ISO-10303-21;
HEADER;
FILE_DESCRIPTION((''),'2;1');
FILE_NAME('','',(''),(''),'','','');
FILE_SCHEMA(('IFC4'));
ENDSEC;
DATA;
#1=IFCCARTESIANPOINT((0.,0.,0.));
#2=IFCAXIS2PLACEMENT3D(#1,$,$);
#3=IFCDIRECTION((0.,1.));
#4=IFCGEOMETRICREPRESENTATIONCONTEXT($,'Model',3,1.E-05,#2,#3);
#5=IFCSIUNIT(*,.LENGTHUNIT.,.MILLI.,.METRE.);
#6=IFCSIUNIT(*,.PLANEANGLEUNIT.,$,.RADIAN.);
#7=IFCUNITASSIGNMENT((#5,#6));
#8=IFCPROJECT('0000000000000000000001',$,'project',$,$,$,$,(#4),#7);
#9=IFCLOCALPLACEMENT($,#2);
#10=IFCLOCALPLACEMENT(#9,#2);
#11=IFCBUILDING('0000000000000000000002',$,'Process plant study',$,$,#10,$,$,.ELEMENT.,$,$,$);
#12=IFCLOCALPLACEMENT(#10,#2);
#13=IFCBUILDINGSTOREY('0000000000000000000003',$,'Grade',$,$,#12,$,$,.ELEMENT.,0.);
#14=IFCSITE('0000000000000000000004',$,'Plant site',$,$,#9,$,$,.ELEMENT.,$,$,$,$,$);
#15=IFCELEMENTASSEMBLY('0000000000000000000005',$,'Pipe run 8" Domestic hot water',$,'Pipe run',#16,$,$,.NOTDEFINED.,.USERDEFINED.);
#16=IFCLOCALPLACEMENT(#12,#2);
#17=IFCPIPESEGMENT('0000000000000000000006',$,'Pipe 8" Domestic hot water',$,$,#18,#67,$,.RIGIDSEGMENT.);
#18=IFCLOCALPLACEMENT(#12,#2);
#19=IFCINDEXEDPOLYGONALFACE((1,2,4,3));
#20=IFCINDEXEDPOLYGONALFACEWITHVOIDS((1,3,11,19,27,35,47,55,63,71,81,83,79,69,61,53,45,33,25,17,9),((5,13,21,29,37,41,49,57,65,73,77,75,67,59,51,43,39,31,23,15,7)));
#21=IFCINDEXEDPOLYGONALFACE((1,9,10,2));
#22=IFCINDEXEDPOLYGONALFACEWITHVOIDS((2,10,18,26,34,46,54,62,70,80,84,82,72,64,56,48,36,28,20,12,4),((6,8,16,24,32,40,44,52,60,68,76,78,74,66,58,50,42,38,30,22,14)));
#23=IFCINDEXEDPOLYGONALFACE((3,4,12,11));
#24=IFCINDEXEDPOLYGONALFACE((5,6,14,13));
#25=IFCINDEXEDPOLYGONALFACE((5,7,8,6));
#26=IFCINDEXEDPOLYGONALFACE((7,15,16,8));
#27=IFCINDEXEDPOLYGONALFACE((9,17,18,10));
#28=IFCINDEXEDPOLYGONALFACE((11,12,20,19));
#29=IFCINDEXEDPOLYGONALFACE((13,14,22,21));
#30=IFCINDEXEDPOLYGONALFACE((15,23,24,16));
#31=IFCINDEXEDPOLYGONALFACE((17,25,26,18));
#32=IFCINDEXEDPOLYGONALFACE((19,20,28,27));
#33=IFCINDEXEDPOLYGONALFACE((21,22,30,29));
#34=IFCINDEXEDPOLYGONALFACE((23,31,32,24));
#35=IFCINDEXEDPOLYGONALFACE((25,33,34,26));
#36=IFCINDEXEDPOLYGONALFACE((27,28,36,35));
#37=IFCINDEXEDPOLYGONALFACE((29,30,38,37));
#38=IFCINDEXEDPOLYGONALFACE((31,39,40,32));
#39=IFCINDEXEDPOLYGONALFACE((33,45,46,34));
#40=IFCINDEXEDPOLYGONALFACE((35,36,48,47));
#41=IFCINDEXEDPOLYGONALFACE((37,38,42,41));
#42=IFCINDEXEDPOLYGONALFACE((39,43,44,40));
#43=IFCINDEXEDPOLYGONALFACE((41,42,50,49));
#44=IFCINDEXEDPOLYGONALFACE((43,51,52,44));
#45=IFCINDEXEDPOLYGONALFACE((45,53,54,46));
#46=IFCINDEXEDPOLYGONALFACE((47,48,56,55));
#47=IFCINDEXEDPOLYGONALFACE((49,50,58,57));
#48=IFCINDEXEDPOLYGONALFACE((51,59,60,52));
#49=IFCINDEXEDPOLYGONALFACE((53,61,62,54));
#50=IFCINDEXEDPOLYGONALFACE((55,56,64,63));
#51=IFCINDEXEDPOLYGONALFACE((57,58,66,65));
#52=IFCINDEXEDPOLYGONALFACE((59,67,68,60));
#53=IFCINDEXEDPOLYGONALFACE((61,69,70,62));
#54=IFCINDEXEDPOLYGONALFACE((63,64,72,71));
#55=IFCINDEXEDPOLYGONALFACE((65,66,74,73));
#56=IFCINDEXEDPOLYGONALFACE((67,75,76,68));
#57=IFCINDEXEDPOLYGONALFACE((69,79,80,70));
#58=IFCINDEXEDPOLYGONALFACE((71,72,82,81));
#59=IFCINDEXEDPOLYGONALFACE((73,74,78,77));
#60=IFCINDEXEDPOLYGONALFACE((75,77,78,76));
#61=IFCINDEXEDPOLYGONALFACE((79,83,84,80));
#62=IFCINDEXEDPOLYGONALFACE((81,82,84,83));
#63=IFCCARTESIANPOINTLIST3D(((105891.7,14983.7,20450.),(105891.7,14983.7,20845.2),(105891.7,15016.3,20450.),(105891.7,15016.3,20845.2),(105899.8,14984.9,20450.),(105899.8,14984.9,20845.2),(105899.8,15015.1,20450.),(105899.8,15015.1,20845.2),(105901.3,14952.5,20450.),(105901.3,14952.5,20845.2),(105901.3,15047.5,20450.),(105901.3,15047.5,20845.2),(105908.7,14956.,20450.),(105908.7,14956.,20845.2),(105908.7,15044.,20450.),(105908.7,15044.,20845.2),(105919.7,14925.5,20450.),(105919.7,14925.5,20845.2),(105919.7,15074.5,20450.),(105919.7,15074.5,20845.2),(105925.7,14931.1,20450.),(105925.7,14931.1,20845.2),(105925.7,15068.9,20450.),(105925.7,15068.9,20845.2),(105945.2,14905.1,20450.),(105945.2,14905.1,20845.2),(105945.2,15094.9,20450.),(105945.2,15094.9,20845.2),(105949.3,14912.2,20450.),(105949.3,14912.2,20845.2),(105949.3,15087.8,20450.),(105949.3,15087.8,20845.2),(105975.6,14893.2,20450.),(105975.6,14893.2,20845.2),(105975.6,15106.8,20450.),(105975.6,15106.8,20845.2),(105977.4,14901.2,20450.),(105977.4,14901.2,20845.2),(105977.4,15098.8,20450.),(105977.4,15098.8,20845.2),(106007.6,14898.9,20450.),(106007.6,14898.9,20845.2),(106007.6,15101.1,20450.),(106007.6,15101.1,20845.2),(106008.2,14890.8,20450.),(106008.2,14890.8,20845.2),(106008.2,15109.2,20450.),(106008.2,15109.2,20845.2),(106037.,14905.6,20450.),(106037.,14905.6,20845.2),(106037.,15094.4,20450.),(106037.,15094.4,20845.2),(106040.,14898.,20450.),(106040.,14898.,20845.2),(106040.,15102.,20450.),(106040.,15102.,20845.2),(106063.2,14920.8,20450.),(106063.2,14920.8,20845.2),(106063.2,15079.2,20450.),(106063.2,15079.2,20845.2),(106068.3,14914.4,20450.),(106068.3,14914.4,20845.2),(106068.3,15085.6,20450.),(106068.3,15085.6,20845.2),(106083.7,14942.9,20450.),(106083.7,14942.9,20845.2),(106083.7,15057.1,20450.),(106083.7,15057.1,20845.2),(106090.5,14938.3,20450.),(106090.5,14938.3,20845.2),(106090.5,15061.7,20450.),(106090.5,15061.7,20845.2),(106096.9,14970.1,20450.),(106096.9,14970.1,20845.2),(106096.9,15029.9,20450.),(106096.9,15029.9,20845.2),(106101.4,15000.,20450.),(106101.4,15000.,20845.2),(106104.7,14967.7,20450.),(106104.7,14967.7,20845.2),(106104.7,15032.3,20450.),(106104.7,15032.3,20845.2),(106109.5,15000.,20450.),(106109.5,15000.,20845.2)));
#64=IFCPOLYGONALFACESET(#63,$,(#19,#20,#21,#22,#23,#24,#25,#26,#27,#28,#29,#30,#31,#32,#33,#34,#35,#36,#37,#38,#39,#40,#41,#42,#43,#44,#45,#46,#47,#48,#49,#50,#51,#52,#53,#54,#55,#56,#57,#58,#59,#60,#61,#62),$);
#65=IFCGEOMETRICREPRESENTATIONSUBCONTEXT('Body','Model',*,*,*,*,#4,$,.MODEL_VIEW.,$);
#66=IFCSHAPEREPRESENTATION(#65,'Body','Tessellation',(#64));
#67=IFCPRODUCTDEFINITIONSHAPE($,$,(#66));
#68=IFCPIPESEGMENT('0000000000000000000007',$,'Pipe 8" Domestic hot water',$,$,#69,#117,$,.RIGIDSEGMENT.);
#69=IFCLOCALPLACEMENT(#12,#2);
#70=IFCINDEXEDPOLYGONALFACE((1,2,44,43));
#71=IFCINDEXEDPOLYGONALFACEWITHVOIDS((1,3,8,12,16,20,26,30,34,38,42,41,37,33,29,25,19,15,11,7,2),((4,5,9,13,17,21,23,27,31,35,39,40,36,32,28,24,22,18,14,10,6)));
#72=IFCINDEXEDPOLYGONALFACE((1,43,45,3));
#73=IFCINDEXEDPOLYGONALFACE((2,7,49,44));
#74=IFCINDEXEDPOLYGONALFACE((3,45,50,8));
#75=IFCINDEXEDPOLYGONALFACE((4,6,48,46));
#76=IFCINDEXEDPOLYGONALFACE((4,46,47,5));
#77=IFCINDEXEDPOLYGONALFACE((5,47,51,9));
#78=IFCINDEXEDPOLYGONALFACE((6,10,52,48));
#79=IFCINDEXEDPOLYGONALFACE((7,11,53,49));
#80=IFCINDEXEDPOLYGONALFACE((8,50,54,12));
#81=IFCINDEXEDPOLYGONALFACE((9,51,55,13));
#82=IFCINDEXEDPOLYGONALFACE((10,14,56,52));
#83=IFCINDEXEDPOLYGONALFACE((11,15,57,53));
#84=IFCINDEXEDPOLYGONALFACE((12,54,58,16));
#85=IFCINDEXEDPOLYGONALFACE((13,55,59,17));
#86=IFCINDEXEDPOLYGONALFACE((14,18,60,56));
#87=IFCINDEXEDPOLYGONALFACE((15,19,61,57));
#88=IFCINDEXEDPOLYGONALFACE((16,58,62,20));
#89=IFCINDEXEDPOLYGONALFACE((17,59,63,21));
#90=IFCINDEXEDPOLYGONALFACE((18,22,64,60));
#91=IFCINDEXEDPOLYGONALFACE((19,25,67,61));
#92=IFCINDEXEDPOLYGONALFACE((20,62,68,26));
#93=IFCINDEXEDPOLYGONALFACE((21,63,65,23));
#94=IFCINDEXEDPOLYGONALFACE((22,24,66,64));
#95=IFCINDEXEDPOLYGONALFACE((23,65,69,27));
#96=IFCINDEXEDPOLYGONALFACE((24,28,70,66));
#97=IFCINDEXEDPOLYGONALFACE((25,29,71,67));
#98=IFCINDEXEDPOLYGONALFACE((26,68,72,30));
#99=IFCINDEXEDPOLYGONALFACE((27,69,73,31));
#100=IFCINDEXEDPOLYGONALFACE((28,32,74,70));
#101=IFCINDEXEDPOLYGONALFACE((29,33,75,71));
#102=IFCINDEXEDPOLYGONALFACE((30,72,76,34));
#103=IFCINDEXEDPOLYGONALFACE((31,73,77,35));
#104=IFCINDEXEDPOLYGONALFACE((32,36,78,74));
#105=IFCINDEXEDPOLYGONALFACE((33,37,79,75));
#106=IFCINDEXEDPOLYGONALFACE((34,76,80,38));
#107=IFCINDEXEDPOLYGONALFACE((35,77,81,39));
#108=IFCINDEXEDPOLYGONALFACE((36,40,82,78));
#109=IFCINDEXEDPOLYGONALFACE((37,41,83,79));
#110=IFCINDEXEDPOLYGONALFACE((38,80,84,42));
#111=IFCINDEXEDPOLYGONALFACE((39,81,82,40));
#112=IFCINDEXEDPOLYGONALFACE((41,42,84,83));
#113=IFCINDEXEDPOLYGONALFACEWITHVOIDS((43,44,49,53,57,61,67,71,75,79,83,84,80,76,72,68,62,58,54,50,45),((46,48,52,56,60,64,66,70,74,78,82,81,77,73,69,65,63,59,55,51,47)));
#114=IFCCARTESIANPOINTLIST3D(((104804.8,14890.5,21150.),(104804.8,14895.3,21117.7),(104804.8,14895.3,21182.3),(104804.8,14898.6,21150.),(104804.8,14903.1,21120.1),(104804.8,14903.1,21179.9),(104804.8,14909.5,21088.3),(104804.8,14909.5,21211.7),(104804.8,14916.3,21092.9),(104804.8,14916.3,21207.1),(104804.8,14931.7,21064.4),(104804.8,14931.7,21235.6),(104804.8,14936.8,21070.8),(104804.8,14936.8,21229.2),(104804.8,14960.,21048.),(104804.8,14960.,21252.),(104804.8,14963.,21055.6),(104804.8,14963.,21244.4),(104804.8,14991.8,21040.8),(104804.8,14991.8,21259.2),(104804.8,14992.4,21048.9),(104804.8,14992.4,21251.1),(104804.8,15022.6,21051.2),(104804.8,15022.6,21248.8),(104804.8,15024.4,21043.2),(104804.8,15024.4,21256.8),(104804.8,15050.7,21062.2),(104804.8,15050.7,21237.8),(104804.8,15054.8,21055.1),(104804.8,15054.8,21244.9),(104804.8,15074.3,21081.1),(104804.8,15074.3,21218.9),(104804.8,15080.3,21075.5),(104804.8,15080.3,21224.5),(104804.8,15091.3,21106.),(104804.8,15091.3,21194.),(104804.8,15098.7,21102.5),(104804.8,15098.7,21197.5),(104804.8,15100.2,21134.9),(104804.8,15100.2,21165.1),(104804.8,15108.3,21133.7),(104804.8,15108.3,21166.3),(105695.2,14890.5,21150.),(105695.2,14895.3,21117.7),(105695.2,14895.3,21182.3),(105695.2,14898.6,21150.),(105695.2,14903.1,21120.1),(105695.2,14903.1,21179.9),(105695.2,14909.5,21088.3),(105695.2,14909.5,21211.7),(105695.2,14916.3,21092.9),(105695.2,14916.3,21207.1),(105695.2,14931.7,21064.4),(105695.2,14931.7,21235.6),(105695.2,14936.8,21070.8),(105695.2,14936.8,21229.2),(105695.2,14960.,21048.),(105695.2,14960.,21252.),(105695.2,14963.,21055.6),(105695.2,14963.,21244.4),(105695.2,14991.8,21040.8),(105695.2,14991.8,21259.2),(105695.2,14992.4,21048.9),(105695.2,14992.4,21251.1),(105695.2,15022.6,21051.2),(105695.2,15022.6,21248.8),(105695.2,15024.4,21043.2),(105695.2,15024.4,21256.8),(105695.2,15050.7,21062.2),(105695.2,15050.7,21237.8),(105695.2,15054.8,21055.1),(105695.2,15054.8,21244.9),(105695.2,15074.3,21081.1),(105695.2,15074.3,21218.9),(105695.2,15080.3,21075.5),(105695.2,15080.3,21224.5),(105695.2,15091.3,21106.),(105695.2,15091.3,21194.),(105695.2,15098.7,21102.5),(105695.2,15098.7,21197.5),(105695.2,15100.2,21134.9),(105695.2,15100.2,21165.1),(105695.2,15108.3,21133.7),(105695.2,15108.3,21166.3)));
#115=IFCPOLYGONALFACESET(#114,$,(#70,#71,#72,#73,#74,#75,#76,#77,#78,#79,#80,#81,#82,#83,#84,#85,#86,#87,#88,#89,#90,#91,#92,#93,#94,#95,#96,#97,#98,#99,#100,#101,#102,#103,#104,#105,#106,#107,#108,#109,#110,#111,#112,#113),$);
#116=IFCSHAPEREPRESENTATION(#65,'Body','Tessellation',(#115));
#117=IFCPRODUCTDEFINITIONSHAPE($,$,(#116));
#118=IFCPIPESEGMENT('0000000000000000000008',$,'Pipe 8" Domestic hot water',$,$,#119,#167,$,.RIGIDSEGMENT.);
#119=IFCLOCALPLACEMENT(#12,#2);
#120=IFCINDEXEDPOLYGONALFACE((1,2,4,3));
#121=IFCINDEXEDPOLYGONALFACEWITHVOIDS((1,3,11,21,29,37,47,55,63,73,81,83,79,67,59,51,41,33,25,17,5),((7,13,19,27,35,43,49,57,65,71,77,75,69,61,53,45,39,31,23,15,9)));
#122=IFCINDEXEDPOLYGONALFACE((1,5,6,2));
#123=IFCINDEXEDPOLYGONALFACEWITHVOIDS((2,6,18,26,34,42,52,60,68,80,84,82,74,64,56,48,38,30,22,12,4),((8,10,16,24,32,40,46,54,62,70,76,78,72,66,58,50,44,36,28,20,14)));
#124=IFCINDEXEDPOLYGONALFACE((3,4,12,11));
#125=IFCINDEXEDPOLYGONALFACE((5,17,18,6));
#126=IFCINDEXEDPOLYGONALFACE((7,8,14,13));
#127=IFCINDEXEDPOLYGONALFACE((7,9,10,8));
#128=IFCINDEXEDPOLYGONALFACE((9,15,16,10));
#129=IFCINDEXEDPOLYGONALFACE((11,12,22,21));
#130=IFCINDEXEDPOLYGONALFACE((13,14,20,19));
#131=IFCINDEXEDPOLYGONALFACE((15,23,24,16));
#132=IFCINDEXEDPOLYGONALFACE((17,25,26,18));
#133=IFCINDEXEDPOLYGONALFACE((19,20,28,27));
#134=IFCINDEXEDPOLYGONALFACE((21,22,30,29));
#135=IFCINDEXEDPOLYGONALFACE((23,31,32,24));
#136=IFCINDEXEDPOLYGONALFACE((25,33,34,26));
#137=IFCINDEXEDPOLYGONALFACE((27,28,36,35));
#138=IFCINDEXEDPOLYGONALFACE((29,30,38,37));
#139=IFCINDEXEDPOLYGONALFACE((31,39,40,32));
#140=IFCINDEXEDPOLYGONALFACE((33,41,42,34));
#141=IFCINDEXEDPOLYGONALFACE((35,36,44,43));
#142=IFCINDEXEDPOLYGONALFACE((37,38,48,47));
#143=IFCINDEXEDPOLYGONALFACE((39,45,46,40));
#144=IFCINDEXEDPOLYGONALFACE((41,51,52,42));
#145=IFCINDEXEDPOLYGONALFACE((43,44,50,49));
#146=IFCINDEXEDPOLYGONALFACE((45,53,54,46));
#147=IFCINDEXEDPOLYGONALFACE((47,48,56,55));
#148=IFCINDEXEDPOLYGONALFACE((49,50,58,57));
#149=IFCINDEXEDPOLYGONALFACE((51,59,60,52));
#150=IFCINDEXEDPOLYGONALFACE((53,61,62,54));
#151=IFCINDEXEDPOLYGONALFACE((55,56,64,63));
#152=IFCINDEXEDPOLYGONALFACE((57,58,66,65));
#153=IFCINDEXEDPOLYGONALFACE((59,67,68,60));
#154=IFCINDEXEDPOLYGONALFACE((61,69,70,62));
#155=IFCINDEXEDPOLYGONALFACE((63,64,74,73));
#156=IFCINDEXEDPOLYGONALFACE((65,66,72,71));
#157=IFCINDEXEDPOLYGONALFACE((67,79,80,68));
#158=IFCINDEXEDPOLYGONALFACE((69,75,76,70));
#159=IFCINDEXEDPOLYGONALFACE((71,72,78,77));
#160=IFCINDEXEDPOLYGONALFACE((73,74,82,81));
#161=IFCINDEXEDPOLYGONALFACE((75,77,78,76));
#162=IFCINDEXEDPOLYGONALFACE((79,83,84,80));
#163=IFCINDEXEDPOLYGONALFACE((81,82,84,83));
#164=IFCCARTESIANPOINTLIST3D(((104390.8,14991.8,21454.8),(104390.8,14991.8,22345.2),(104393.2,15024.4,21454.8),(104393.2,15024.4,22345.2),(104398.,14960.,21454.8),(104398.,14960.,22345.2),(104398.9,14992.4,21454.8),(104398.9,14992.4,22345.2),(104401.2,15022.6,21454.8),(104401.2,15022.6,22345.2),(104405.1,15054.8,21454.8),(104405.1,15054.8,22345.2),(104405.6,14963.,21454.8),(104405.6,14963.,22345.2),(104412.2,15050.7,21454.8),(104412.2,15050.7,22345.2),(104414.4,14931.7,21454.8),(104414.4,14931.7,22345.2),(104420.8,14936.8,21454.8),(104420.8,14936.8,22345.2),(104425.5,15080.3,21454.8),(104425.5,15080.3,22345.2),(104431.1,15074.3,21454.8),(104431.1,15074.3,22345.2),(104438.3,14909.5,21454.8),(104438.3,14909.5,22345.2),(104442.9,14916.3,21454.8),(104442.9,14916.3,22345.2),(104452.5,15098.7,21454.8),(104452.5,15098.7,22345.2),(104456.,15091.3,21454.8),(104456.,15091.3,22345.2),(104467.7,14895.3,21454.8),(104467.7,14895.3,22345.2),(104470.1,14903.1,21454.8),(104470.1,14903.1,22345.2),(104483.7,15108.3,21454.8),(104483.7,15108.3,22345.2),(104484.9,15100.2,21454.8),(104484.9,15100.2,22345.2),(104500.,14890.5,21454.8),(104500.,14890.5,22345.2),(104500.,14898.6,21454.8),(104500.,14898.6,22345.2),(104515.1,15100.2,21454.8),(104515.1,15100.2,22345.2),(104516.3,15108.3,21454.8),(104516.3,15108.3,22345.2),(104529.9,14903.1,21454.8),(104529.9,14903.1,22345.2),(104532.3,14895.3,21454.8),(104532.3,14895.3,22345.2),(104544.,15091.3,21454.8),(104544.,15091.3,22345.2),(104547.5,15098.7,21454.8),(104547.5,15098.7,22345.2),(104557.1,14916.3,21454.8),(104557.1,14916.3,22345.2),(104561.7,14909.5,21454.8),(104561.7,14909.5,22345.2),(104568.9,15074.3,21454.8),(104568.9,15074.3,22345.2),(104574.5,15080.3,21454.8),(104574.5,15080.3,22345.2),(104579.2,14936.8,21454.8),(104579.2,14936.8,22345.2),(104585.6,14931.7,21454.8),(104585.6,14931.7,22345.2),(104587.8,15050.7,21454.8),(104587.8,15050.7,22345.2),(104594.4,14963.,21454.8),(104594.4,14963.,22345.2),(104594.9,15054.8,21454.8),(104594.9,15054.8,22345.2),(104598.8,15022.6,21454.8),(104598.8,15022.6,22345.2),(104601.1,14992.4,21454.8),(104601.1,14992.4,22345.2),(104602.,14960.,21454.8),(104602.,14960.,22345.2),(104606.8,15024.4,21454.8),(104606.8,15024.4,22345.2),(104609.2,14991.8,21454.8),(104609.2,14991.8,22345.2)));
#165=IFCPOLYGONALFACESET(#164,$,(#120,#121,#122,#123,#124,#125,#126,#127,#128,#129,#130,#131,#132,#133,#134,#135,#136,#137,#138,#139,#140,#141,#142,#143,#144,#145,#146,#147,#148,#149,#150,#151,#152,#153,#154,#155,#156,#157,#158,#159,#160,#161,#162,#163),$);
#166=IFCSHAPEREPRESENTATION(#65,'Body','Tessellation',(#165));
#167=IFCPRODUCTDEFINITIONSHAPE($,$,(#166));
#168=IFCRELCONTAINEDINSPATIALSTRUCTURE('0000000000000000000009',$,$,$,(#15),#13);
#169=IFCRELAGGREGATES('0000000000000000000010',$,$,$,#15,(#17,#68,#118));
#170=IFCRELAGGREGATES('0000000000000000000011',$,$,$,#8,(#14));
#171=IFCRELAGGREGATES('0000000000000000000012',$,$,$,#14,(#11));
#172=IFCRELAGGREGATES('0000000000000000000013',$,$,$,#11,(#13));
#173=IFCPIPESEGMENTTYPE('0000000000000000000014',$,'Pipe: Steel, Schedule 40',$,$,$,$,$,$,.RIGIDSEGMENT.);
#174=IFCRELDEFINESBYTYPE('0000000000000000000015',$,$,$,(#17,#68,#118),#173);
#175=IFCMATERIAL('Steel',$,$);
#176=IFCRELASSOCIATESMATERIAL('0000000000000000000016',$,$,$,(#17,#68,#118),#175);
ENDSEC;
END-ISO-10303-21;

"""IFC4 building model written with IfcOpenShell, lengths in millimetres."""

from ifc_helpers import new_model, si_unit, direction, frame, origin, origin_with_axes, origin_2d, place, context, subcontext, project, spatial, hollow_circle, extrude, material, type_object, element, aggregate, save


model = new_model("IFC4")

# Units and contexts
model_context = context("Model", 3, precision=1e-05, world=origin(), true_north=direction((0.0, 1.0)))
body_context = subcontext(model_context, "Body", "Model", "MODEL_VIEW")
ifc_project = project(units=[si_unit("LENGTHUNIT", "METRE", prefix="MILLI"), si_unit("PLANEANGLEUNIT", "RADIAN")], contexts=[model_context])

# Site, building, storey
site_placement = place(None, origin())
site = spatial("IfcSite", under=ifc_project, at=site_placement, Name="Plant site", CompositionType="ELEMENT")
building_placement = place(site_placement, origin())
building = spatial("IfcBuilding", under=site, at=building_placement, Name="Process plant study", CompositionType="ELEMENT")
storey_placement = place(building_placement, origin())
storey = spatial("IfcBuildingStorey", under=building, at=storey_placement, Name="Grade", CompositionType="ELEMENT", Elevation=0.0)

# Element assembly, pipe segments
ifc_material = material(Name="Steel")
pipe_segment_type = type_object("IfcPipeSegmentType", Name="Pipe: Steel, Schedule 40", PredefinedType="RIGIDSEGMENT")
assembly_1_placement = place(storey_placement, origin_with_axes())
assembly_1 = element("IfcElementAssembly", 1, at=assembly_1_placement, inside=storey, Name="Pipe run 8\" Domestic hot water", ObjectType="Pipe run", AssemblyPlace="NOTDEFINED", PredefinedType="USERDEFINED")
pipe_segment_1_placement = place(storey_placement, origin_with_axes())
pipe_segment_1 = element("IfcPipeSegment", 2, at=pipe_segment_1_placement, type_object=pipe_segment_type, material=ifc_material, Name="Pipe 8\" Domestic hot water", PredefinedType="RIGIDSEGMENT", context=body_context, shape_type="SweptSolid", body=[
    extrude(hollow_circle(Radius=109.5, WallThickness=8.2, at=origin_2d()), frame((106000.0, 15000.0, 20450.0), z_axis=(0.0, 0.0, 1.0), x_axis=(1.0, 0.0, 0.0)), (0.0, 0.0, 1.0), 395.2),
])
pipe_segment_2_placement = place(storey_placement, origin_with_axes())
pipe_segment_2 = element("IfcPipeSegment", 3, at=pipe_segment_2_placement, type_object=pipe_segment_type, material=ifc_material, Name="Pipe 8\" Domestic hot water", PredefinedType="RIGIDSEGMENT", context=body_context, shape_type="SweptSolid", body=[
    extrude(hollow_circle(Radius=109.5, WallThickness=8.2, at=origin_2d()), frame((105695.2, 15000.0, 21150.0), z_axis=(-1.0, 0.0, 0.0), x_axis=(0.0, -1.0, 0.0)), (0.0, 0.0, 1.0), 890.4),
])
pipe_segment_3_placement = place(storey_placement, origin_with_axes())
pipe_segment_3 = element("IfcPipeSegment", 4, at=pipe_segment_3_placement, type_object=pipe_segment_type, material=ifc_material, Name="Pipe 8\" Domestic hot water", PredefinedType="RIGIDSEGMENT", context=body_context, shape_type="SweptSolid", body=[
    extrude(hollow_circle(Radius=109.5, WallThickness=8.2, at=origin_2d()), frame((104500.0, 15000.0, 21454.8), z_axis=(0.0, 0.0, 1.0), x_axis=(0.0, -1.0, 0.0)), (0.0, 0.0, 1.0), 890.4),
])

aggregate(assembly_1, [pipe_segment_1, pipe_segment_2, pipe_segment_3])

save(model, "model.ifc")
